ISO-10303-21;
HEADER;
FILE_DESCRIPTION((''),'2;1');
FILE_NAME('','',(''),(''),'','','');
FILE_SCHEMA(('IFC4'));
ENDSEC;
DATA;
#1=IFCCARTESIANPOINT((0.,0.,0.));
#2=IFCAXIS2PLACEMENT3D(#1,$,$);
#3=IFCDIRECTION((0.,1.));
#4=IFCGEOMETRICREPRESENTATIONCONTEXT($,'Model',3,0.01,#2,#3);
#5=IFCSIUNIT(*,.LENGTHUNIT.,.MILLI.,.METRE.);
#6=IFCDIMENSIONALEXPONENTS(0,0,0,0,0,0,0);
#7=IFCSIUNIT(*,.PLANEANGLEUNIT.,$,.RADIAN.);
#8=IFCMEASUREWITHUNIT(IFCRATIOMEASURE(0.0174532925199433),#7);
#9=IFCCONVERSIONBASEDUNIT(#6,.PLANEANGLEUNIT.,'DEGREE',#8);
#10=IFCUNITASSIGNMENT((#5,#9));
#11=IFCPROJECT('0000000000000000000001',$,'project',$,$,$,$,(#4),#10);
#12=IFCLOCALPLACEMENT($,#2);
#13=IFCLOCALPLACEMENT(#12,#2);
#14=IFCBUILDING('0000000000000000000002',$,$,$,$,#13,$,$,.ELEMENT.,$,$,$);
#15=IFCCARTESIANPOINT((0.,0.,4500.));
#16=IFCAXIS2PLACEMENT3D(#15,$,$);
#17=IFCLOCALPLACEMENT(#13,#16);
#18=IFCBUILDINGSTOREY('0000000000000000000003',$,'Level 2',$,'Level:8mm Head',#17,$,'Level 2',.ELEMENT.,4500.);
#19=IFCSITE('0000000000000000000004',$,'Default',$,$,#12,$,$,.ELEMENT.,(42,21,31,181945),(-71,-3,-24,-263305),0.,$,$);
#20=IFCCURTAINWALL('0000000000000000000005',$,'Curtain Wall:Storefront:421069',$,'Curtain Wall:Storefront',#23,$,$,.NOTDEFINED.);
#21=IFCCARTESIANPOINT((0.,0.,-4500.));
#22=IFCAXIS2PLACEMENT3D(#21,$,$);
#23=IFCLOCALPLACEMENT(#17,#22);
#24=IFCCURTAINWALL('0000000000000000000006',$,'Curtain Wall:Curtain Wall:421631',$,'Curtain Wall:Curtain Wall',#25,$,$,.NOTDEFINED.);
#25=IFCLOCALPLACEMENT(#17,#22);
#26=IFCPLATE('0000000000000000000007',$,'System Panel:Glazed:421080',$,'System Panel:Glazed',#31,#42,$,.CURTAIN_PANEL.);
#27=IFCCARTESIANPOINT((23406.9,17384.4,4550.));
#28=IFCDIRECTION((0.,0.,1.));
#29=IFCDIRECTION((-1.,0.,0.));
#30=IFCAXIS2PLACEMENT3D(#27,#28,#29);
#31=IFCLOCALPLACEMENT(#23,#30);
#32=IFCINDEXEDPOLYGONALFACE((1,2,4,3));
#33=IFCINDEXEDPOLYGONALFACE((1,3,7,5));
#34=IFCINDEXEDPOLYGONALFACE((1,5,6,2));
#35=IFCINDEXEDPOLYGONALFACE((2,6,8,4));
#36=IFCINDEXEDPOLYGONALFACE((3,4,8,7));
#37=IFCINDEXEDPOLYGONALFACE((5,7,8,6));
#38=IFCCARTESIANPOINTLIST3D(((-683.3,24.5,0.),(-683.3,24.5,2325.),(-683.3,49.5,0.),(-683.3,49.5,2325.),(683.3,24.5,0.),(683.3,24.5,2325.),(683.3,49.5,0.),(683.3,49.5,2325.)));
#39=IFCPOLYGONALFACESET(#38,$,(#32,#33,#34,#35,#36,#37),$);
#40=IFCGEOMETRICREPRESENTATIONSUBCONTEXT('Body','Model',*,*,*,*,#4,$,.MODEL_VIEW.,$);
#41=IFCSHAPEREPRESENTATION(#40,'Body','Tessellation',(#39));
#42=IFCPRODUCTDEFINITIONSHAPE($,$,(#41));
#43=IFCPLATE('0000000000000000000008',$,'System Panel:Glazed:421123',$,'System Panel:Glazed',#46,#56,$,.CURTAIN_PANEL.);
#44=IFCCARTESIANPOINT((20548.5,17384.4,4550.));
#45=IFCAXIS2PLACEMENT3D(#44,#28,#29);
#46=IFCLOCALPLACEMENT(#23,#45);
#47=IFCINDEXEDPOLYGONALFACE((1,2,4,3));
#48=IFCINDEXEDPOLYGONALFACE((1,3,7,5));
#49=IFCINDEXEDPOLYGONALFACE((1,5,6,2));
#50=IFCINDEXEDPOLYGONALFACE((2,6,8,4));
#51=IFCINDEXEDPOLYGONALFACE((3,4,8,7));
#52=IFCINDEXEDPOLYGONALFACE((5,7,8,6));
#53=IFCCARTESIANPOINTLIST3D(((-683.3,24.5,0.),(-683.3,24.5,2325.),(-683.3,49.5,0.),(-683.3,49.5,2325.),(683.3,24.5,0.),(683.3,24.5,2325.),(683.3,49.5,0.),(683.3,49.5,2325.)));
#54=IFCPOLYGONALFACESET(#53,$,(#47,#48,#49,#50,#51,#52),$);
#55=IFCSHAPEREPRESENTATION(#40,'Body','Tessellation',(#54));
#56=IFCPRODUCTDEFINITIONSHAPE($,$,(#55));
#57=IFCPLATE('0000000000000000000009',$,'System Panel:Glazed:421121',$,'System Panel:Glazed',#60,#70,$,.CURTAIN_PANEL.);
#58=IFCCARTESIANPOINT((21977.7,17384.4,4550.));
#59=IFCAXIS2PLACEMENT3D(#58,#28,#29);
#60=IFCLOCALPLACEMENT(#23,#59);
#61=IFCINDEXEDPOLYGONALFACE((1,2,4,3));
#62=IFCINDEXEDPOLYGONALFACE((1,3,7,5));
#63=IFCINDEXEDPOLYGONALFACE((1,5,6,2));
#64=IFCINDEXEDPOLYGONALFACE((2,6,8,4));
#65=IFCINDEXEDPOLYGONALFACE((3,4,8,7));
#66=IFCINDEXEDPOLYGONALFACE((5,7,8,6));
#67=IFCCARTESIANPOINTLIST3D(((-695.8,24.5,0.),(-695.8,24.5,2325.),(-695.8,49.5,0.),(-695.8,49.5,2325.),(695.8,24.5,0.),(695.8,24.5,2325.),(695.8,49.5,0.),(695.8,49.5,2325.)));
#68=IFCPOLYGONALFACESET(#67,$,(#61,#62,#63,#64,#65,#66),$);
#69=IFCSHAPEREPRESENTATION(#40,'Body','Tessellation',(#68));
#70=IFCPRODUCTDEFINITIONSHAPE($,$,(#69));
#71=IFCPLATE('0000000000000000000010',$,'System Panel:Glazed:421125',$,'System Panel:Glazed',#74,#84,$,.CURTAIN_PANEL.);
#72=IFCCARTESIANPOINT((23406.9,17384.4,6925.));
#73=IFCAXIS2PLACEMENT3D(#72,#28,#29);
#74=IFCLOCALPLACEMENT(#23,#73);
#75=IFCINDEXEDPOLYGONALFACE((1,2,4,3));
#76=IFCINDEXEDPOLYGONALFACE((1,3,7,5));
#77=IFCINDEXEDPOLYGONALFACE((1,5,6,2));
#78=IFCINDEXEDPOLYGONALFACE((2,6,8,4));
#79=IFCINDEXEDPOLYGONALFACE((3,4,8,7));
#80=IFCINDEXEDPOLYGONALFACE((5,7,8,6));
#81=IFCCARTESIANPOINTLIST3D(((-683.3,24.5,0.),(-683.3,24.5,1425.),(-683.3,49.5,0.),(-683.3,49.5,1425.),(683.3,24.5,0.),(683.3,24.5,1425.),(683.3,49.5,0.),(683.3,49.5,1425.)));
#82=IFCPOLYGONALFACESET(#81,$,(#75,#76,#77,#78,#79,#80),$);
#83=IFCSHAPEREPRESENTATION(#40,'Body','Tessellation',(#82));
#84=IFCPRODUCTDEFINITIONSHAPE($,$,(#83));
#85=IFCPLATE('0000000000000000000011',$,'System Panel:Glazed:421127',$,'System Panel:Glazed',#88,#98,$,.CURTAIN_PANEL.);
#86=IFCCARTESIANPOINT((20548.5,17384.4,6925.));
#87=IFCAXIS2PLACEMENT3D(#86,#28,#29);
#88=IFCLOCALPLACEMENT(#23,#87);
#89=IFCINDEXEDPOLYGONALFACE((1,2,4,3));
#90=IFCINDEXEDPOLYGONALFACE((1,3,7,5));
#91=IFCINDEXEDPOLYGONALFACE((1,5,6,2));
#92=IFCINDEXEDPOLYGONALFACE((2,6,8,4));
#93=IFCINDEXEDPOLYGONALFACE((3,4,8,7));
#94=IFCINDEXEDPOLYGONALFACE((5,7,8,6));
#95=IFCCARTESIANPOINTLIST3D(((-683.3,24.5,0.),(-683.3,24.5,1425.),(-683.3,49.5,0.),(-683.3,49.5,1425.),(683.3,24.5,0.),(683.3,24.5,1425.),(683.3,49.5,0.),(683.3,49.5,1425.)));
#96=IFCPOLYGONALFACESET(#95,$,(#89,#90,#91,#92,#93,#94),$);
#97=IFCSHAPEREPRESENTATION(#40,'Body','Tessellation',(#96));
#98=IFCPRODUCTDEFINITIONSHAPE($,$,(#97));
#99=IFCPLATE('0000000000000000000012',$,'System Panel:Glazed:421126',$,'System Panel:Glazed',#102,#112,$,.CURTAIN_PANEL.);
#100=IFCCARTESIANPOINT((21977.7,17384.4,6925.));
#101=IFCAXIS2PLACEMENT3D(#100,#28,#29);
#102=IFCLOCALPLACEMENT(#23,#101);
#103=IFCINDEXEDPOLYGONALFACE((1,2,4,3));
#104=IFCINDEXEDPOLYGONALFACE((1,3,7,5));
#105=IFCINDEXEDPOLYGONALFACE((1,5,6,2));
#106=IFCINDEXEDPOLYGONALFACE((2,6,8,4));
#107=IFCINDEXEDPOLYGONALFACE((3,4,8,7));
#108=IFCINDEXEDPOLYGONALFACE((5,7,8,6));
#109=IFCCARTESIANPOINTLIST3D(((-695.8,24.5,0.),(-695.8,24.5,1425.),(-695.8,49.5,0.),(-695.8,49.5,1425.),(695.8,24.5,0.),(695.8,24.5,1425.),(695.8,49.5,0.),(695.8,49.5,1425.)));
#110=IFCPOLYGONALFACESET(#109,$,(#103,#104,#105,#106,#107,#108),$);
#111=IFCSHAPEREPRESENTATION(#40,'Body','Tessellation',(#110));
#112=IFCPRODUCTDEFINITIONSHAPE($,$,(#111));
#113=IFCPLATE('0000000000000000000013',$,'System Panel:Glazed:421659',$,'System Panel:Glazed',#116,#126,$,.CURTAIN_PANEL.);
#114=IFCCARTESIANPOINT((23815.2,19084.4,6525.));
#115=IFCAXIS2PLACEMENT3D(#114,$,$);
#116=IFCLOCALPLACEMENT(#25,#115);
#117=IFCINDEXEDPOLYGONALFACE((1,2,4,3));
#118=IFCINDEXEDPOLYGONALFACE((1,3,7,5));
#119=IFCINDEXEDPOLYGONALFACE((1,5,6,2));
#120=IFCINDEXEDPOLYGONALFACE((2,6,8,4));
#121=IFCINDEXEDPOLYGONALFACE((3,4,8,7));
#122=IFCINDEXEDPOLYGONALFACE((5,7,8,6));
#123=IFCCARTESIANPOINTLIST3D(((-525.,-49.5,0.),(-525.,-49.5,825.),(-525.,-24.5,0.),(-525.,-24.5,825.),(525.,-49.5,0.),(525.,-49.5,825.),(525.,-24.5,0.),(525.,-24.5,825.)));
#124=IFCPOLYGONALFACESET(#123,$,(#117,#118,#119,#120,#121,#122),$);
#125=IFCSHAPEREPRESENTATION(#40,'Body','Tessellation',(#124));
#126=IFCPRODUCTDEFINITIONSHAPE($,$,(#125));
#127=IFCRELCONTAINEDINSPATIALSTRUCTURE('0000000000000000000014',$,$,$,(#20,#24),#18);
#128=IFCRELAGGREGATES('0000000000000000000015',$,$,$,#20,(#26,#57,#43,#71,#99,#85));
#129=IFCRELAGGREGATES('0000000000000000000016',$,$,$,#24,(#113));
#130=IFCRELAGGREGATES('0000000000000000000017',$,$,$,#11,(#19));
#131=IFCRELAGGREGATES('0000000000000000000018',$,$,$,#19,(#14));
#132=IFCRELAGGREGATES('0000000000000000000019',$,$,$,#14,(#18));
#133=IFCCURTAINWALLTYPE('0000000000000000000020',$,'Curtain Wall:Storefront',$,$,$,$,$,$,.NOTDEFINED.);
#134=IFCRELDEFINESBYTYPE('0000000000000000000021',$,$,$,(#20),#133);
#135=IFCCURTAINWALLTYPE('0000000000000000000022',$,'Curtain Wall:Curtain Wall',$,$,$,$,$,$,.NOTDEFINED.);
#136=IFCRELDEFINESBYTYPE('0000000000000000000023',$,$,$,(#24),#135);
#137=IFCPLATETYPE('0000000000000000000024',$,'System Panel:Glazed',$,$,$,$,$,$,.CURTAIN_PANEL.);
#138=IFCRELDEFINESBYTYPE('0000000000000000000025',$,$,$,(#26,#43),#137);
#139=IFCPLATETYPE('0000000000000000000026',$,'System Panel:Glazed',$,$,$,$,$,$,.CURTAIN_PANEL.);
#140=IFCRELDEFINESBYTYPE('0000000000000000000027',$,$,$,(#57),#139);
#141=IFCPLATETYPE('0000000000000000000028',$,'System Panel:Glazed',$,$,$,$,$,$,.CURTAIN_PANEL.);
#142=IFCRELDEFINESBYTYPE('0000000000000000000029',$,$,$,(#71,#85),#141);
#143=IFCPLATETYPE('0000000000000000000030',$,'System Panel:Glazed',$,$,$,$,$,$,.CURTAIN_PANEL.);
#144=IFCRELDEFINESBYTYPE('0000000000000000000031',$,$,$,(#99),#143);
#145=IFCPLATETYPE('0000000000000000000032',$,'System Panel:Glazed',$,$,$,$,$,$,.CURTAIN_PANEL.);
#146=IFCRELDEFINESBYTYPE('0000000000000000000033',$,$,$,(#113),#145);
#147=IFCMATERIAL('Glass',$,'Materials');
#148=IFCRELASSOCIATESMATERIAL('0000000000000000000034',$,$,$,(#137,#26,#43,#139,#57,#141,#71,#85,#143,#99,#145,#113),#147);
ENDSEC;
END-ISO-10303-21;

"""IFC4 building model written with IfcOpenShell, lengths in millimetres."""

from ifc_helpers import new_model, entity, si_unit, converted_unit, direction, frame, origin, place, context, subcontext, project, spatial, indexed_curve, outline, extrude, shape, source, transform, mapped, material, type_object, type_shapes, element, aggregate, save


model = new_model("IFC4")

# Units and contexts
model_context = context("Model", 3, precision=0.01, world=origin(), true_north=direction((0.0, 1.0)))
body_context = subcontext(model_context, "Body", "Model", "MODEL_VIEW")
footprint_context = subcontext(model_context, "FootPrint", "Model", "MODEL_VIEW")
ifc_project = project(units=[si_unit("LENGTHUNIT", "METRE", prefix="MILLI"), converted_unit("PLANEANGLEUNIT", "DEGREE", entity("IfcRatioMeasure", 0.0174532925199433), si_unit("PLANEANGLEUNIT", "RADIAN"), dimensions=[0, 0, 0, 0, 0, 0, 0])], contexts=[model_context])

# Site, building, storey
site_placement = place(None, origin())
site = spatial("IfcSite", under=ifc_project, at=site_placement, Name="Default", CompositionType="ELEMENT", RefLatitude=(42, 21, 31, 181945), RefLongitude=(-71, -3, -24, -263305), RefElevation=0.0)
building_placement = place(site_placement, origin())
building = spatial("IfcBuilding", under=site, at=building_placement, CompositionType="ELEMENT")
storey_placement = place(building_placement, frame((0.0, 0.0, 4500.0)))
storey = spatial("IfcBuildingStorey", under=building, at=storey_placement, Name="Level 2", ObjectType="Level:8mm Head", LongName="Level 2", CompositionType="ELEMENT", Elevation=4500.0)

# Curtain walls
curtain_wall_type_1 = type_object("IfcCurtainWallType", Name="Curtain Wall:Storefront", PredefinedType="NOTDEFINED")
curtain_wall_1_placement = place(storey_placement, frame((0.0, 0.0, -4500.0)))
curtain_wall_1 = element("IfcCurtainWall", 1, at=curtain_wall_1_placement, inside=storey, type_object=curtain_wall_type_1, Name="Curtain Wall:Storefront:421069", ObjectType="Curtain Wall:Storefront", PredefinedType="NOTDEFINED")
curtain_wall_type_2 = type_object("IfcCurtainWallType", Name="Curtain Wall:Curtain Wall", PredefinedType="NOTDEFINED")
curtain_wall_2_placement = place(storey_placement, frame((0.0, 0.0, -4500.0)))
curtain_wall_2 = element("IfcCurtainWall", 2, at=curtain_wall_2_placement, inside=storey, type_object=curtain_wall_type_2, Name="Curtain Wall:Curtain Wall:421631", ObjectType="Curtain Wall:Curtain Wall", PredefinedType="NOTDEFINED")

# Plates
ifc_material_1 = material(Name="Glass", Category="Materials")
plate_type_1 = type_object("IfcPlateType", Name="System Panel:Glazed", PredefinedType="CURTAIN_PANEL", material=ifc_material_1)
shared_shape_1 = source(origin(), body_context, "Body", "SweptSolid", [
    extrude(outline(indexed_curve([(-12.5, -683.3), (12.5, -683.3), (12.5, 683.3), (-12.5, 683.3), (-12.5, -683.3)], self_intersect=False)), frame((0.0, 37.0, 0.0), z_axis=(0.0, 0.0, 1.0), x_axis=(0.0, 1.0, 0.0)), (0.0, 0.0, 1.0), 2325.0),
])
shared_shape_2 = source(origin(), footprint_context, "FootPrint", "Curve2D", [
    entity("IfcIndexedPolyCurve", entity("IfcCartesianPointList2D", [[683.3, 24.5], [683.3, 49.5], [-683.3, 49.5], [-683.3, 24.5], [683.3, 24.5]]), None, False),
])
type_shapes(plate_type_1, [shared_shape_1, shared_shape_2])
plate_1_placement = place(curtain_wall_1_placement, frame((23406.9, 17384.4, 4550.0), z_axis=(0.0, 0.0, 1.0), x_axis=(-1.0, 0.0, 0.0)))
plate_1 = element("IfcPlate", 3, at=plate_1_placement, type_object=plate_type_1, material=ifc_material_1, Name="System Panel:Glazed:421080", ObjectType="System Panel:Glazed", PredefinedType="CURTAIN_PANEL", shapes=[
    shape(body_context, "Body", "MappedRepresentation", [mapped(shared_shape_1, transform((0.0, 0.0, 0.0), scale=1.0))]),
    shape(body_context, "Body", "MappedRepresentation", [mapped(shared_shape_2, transform((0.0, 0.0, 0.0), scale=1.0))]),
])
plate_2_placement = place(curtain_wall_1_placement, frame((20548.5, 17384.4, 4550.0), z_axis=(0.0, 0.0, 1.0), x_axis=(-1.0, 0.0, 0.0)))
plate_2 = element("IfcPlate", 4, at=plate_2_placement, type_object=plate_type_1, material=ifc_material_1, Name="System Panel:Glazed:421123", ObjectType="System Panel:Glazed", PredefinedType="CURTAIN_PANEL", shapes=[
    shape(body_context, "Body", "MappedRepresentation", [mapped(shared_shape_1, transform((0.0, 0.0, 0.0), scale=1.0))]),
    shape(body_context, "Body", "MappedRepresentation", [mapped(shared_shape_2, transform((0.0, 0.0, 0.0), scale=1.0))]),
])
plate_type_2 = type_object("IfcPlateType", Name="System Panel:Glazed", PredefinedType="CURTAIN_PANEL", material=ifc_material_1)
shared_shape_3 = source(origin(), body_context, "Body", "SweptSolid", [
    extrude(outline(indexed_curve([(-12.5, -695.8), (12.5, -695.8), (12.5, 695.8), (-12.5, 695.8), (-12.5, -695.8)], self_intersect=False)), frame((0.0, 37.0, 0.0), z_axis=(0.0, 0.0, 1.0), x_axis=(0.0, 1.0, 0.0)), (0.0, 0.0, 1.0), 2325.0),
])
shared_shape_4 = source(origin(), footprint_context, "FootPrint", "Curve2D", [
    entity("IfcIndexedPolyCurve", entity("IfcCartesianPointList2D", [[695.8, 24.5], [695.8, 49.5], [-695.8, 49.5], [-695.8, 24.5], [695.8, 24.5]]), None, False),
])
type_shapes(plate_type_2, [shared_shape_3, shared_shape_4])
plate_3_placement = place(curtain_wall_1_placement, frame((21977.7, 17384.4, 4550.0), z_axis=(0.0, 0.0, 1.0), x_axis=(-1.0, 0.0, 0.0)))
plate_3 = element("IfcPlate", 5, at=plate_3_placement, type_object=plate_type_2, material=ifc_material_1, Name="System Panel:Glazed:421121", ObjectType="System Panel:Glazed", PredefinedType="CURTAIN_PANEL", shapes=[
    shape(body_context, "Body", "MappedRepresentation", [mapped(shared_shape_3, transform((0.0, 0.0, 0.0), scale=1.0))]),
    shape(body_context, "Body", "MappedRepresentation", [mapped(shared_shape_4, transform((0.0, 0.0, 0.0), scale=1.0))]),
])
plate_type_3 = type_object("IfcPlateType", Name="System Panel:Glazed", PredefinedType="CURTAIN_PANEL", material=ifc_material_1)
shared_shape_5 = source(origin(), body_context, "Body", "SweptSolid", [
    extrude(outline(indexed_curve([(-12.5, -683.3), (12.5, -683.3), (12.5, 683.3), (-12.5, 683.3), (-12.5, -683.3)], self_intersect=False)), frame((0.0, 37.0, 0.0), z_axis=(0.0, 0.0, 1.0), x_axis=(0.0, 1.0, 0.0)), (0.0, 0.0, 1.0), 1425.0),
])
shared_shape_6 = source(origin(), footprint_context, "FootPrint", "Curve2D", [
    entity("IfcIndexedPolyCurve", entity("IfcCartesianPointList2D", [[683.3, 24.5], [683.3, 49.5], [-683.3, 49.5], [-683.3, 24.5], [683.3, 24.5]]), None, False),
])
type_shapes(plate_type_3, [shared_shape_5, shared_shape_6])
plate_4_placement = place(curtain_wall_1_placement, frame((23406.9, 17384.4, 6925.0), z_axis=(0.0, 0.0, 1.0), x_axis=(-1.0, 0.0, 0.0)))
plate_4 = element("IfcPlate", 6, at=plate_4_placement, type_object=plate_type_3, material=ifc_material_1, Name="System Panel:Glazed:421125", ObjectType="System Panel:Glazed", PredefinedType="CURTAIN_PANEL", shapes=[
    shape(body_context, "Body", "MappedRepresentation", [mapped(shared_shape_5, transform((0.0, 0.0, 0.0), scale=1.0))]),
    shape(body_context, "Body", "MappedRepresentation", [mapped(shared_shape_6, transform((0.0, 0.0, 0.0), scale=1.0))]),
])
plate_5_placement = place(curtain_wall_1_placement, frame((20548.5, 17384.4, 6925.0), z_axis=(0.0, 0.0, 1.0), x_axis=(-1.0, 0.0, 0.0)))
plate_5 = element("IfcPlate", 7, at=plate_5_placement, type_object=plate_type_3, material=ifc_material_1, Name="System Panel:Glazed:421127", ObjectType="System Panel:Glazed", PredefinedType="CURTAIN_PANEL", shapes=[
    shape(body_context, "Body", "MappedRepresentation", [mapped(shared_shape_5, transform((0.0, 0.0, 0.0), scale=1.0))]),
    shape(body_context, "Body", "MappedRepresentation", [mapped(shared_shape_6, transform((0.0, 0.0, 0.0), scale=1.0))]),
])
plate_type_4 = type_object("IfcPlateType", Name="System Panel:Glazed", PredefinedType="CURTAIN_PANEL", material=ifc_material_1)
shared_shape_7 = source(origin(), body_context, "Body", "SweptSolid", [
    extrude(outline(indexed_curve([(-12.5, -695.8), (12.5, -695.8), (12.5, 695.8), (-12.5, 695.8), (-12.5, -695.8)], self_intersect=False)), frame((0.0, 37.0, 0.0), z_axis=(0.0, 0.0, 1.0), x_axis=(0.0, 1.0, 0.0)), (0.0, 0.0, 1.0), 1425.0),
])
shared_shape_8 = source(origin(), footprint_context, "FootPrint", "Curve2D", [
    entity("IfcIndexedPolyCurve", entity("IfcCartesianPointList2D", [[695.8, 24.5], [695.8, 49.5], [-695.8, 49.5], [-695.8, 24.5], [695.8, 24.5]]), None, False),
])
type_shapes(plate_type_4, [shared_shape_7, shared_shape_8])
plate_6_placement = place(curtain_wall_1_placement, frame((21977.7, 17384.4, 6925.0), z_axis=(0.0, 0.0, 1.0), x_axis=(-1.0, 0.0, 0.0)))
plate_6 = element("IfcPlate", 8, at=plate_6_placement, type_object=plate_type_4, material=ifc_material_1, Name="System Panel:Glazed:421126", ObjectType="System Panel:Glazed", PredefinedType="CURTAIN_PANEL", shapes=[
    shape(body_context, "Body", "MappedRepresentation", [mapped(shared_shape_7, transform((0.0, 0.0, 0.0), scale=1.0))]),
    shape(body_context, "Body", "MappedRepresentation", [mapped(shared_shape_8, transform((0.0, 0.0, 0.0), scale=1.0))]),
])
aggregate(curtain_wall_1, [plate_1, plate_3, plate_2, plate_4, plate_6, plate_5])
plate_type_5 = type_object("IfcPlateType", Name="System Panel:Glazed", PredefinedType="CURTAIN_PANEL", material=ifc_material_1)
shared_shape_9 = source(origin(), body_context, "Body", "SweptSolid", [
    extrude(outline(indexed_curve([(-12.5, -525.0), (12.5, -525.0), (12.5, 525.0), (-12.5, 525.0), (-12.5, -525.0)], self_intersect=False)), frame((0.0, -37.0, 0.0), z_axis=(0.0, 0.0, 1.0), x_axis=(0.0, 1.0, 0.0)), (0.0, 0.0, 1.0), 825.0),
])
shared_shape_10 = source(origin(), footprint_context, "FootPrint", "Curve2D", [
    entity("IfcIndexedPolyCurve", entity("IfcCartesianPointList2D", [[525.0, -49.5], [525.0, -24.5], [-525.0, -24.5], [-525.0, -49.5], [525.0, -49.5]]), None, False),
])
type_shapes(plate_type_5, [shared_shape_9, shared_shape_10])
plate_7_placement = place(curtain_wall_2_placement, frame((23815.2, 19084.4, 6525.0)))
plate_7 = element("IfcPlate", 9, at=plate_7_placement, type_object=plate_type_5, material=ifc_material_1, Name="System Panel:Glazed:421659", ObjectType="System Panel:Glazed", PredefinedType="CURTAIN_PANEL", shapes=[
    shape(body_context, "Body", "MappedRepresentation", [mapped(shared_shape_9, transform((0.0, 0.0, 0.0), scale=1.0))]),
    shape(body_context, "Body", "MappedRepresentation", [mapped(shared_shape_10, transform((0.0, 0.0, 0.0), scale=1.0))]),
])

aggregate(curtain_wall_2, [plate_7])

save(model, "model.ifc")
